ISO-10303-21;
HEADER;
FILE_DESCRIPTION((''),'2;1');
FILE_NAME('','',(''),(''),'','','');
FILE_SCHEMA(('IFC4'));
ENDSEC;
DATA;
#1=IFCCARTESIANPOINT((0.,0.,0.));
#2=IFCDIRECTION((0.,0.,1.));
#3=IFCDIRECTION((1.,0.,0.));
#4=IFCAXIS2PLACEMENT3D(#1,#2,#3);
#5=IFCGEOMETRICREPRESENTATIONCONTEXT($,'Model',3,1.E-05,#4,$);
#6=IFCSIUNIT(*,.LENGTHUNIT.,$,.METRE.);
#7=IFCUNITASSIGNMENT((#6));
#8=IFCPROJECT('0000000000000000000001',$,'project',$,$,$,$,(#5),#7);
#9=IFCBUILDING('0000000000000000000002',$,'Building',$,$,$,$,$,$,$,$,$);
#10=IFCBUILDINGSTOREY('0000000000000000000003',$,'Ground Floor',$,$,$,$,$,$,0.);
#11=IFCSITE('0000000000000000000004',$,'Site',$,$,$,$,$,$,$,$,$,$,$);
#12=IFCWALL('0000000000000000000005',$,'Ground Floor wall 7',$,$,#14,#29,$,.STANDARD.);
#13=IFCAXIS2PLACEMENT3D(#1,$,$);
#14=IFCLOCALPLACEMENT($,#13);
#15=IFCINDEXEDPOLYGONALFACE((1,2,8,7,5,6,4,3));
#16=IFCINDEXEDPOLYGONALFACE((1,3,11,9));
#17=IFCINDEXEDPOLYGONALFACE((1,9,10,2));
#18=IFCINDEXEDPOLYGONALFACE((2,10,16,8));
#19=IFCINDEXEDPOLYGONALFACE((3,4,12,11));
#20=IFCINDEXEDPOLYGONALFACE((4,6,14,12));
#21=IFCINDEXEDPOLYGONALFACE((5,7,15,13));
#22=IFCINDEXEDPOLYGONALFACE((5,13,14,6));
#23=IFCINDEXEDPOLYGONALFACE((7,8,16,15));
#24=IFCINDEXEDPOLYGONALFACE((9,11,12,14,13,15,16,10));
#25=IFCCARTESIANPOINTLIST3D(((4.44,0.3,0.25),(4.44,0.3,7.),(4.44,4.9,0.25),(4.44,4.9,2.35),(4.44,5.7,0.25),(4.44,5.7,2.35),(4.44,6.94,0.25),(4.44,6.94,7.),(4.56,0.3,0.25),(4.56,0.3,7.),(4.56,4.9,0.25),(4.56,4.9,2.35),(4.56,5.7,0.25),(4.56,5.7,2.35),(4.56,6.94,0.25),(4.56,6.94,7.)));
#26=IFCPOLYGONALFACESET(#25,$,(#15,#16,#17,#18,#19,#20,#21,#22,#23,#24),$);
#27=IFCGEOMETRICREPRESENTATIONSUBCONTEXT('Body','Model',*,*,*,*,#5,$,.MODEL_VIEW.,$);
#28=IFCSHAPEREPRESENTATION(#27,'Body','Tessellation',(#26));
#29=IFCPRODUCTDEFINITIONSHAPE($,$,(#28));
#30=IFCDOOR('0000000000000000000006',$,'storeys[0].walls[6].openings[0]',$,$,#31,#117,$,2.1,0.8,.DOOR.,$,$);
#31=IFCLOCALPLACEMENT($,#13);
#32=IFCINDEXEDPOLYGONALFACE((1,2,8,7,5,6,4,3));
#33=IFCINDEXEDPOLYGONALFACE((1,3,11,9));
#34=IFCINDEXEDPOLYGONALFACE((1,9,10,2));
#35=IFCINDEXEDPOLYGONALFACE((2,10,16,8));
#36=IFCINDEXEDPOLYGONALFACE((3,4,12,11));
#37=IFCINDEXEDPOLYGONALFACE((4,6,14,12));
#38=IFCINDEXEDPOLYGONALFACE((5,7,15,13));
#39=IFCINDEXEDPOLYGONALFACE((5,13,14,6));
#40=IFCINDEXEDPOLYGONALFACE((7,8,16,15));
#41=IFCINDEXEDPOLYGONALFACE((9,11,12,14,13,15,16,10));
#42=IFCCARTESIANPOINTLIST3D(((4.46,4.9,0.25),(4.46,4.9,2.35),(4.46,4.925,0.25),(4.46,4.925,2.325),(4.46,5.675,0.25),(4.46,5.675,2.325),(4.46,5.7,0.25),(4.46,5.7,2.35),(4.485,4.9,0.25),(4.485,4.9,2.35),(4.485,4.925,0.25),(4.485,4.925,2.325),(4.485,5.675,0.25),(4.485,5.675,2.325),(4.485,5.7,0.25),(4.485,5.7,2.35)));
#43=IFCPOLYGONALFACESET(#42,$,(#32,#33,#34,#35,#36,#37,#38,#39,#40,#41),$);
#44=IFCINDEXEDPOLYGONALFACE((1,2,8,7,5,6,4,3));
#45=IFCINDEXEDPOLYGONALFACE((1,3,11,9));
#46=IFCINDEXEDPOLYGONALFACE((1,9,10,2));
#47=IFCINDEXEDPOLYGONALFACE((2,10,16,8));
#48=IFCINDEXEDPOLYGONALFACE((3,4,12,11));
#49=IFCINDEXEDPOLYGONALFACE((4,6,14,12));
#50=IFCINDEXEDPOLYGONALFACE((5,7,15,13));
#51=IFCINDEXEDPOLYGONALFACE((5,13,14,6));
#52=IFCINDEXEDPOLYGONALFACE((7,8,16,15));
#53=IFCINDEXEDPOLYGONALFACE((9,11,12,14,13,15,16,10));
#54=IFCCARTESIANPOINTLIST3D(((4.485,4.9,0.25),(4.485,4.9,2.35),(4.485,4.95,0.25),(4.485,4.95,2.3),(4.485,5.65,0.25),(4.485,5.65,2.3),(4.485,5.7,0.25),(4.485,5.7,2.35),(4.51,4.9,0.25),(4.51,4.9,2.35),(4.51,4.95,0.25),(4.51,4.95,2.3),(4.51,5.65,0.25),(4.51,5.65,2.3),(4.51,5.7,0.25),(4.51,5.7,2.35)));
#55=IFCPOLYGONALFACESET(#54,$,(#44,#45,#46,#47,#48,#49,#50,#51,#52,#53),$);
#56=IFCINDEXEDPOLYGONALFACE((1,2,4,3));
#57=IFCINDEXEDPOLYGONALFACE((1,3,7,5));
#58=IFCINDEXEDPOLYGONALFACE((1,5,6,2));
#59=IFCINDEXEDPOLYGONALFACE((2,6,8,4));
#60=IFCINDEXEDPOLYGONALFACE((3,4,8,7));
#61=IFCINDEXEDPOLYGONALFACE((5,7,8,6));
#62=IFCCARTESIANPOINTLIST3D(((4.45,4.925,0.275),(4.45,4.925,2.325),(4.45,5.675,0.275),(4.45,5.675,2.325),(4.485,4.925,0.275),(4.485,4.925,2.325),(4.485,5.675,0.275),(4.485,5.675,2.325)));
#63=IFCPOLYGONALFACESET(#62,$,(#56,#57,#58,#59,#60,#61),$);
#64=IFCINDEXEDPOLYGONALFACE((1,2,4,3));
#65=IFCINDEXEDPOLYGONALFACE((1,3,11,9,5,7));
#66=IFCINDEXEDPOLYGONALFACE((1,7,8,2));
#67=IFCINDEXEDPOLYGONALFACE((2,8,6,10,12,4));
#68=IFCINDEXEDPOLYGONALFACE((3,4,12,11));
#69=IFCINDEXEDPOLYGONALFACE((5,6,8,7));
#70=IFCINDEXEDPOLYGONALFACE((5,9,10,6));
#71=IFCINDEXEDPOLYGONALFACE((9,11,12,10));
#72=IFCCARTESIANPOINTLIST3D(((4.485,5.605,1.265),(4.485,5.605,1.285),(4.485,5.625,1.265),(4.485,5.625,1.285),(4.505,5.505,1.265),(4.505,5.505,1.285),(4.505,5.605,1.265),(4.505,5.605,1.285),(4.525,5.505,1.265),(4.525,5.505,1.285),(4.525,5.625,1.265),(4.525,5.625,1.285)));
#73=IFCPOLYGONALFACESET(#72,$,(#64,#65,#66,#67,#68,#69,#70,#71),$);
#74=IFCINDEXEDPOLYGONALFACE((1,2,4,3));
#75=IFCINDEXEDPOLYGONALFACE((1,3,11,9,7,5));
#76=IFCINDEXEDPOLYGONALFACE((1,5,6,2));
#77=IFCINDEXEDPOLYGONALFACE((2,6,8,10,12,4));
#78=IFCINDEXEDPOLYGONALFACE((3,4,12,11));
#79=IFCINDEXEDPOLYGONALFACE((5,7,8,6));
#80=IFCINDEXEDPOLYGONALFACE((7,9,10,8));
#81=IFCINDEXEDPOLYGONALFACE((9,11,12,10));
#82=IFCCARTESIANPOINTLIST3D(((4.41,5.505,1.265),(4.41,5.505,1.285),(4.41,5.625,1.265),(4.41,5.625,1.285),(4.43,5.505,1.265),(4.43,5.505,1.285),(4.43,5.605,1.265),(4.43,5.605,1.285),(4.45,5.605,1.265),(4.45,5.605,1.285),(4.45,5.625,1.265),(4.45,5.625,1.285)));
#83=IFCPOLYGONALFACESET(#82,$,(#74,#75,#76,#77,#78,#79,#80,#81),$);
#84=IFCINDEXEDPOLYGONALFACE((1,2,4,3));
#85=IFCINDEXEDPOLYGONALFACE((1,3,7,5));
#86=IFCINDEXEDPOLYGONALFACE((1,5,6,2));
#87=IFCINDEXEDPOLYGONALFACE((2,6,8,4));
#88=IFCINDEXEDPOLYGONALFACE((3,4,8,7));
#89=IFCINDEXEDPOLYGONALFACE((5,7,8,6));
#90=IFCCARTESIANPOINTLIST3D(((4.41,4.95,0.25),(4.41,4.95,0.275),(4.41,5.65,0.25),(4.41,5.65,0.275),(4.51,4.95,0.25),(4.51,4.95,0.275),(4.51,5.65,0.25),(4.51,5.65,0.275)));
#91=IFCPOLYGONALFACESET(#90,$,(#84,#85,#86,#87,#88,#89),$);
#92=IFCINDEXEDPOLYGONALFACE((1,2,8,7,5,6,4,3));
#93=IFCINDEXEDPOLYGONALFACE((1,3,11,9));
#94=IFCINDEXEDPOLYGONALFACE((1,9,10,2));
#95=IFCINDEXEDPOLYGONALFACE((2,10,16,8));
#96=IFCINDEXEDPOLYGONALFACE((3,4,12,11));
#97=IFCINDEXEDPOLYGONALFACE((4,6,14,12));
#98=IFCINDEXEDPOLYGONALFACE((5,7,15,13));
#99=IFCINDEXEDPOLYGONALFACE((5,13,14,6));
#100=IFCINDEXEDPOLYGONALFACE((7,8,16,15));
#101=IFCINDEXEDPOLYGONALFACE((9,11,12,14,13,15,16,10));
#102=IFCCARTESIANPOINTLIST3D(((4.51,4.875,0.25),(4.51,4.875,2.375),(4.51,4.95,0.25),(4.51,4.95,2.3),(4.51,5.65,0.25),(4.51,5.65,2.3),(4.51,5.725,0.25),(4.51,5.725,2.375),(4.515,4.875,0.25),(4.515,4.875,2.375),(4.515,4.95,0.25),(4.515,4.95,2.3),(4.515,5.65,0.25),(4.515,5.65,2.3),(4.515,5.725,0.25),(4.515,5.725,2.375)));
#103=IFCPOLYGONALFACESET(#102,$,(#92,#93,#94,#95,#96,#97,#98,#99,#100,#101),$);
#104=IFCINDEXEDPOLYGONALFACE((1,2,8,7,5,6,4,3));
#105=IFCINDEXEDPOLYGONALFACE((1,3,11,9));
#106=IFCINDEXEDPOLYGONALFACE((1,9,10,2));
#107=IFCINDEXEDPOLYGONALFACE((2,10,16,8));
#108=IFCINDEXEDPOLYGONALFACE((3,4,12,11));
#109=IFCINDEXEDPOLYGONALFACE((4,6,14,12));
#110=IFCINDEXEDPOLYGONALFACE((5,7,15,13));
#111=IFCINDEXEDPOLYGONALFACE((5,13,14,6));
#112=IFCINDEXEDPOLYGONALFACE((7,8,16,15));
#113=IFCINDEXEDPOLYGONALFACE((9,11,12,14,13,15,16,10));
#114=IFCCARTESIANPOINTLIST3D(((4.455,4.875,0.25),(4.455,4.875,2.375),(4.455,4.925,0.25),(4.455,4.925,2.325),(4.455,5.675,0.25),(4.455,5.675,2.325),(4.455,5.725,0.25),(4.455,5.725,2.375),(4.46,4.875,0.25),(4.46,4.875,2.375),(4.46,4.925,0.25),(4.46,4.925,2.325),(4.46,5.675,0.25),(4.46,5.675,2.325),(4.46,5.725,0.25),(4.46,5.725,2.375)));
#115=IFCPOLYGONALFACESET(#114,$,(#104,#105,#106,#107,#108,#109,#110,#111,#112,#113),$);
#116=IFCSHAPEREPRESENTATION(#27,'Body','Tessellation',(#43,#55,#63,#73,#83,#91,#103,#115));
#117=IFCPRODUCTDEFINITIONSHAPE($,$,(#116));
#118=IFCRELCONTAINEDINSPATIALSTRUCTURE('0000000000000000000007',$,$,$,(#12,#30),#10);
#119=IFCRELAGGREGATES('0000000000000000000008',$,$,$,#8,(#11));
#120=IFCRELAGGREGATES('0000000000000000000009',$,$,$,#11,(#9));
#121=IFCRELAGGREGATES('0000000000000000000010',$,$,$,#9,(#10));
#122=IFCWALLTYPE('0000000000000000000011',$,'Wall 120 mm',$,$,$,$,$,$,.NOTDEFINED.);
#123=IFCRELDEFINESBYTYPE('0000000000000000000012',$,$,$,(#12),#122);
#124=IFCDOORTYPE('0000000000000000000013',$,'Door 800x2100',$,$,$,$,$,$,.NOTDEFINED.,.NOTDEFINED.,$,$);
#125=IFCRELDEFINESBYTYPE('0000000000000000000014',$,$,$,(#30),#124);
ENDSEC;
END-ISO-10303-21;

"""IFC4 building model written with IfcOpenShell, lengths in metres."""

from ifc_helpers import new_model, si_unit, frame, origin_with_axes, place, context, subcontext, project, spatial, line, indexed_curve, outline, extrude, type_object, element, fill, save


model = new_model("IFC4")

# Units and contexts
model_context = context("Model", 3, precision=1e-05, world=origin_with_axes())
body_context = subcontext(model_context, "Body", "Model", "MODEL_VIEW")
ifc_project = project(units=[si_unit("LENGTHUNIT", "METRE")], contexts=[model_context])

# Site, building, storey
site = spatial("IfcSite", under=ifc_project, Name="Site")
building = spatial("IfcBuilding", under=site, Name="Building")
storey = spatial("IfcBuildingStorey", under=building, Name="Ground Floor", Elevation=0.0)

# Wall, opening, door
wall_type_1 = type_object("IfcWallType", Name="Wall 120 mm", PredefinedType="NOTDEFINED")
wall_1_placement = place(None, frame((4.5, 0.3, 0.25), z_axis=(0.0, 0.0, 1.0), x_axis=(0.0, 1.0, 0.0)))
wall_1 = element("IfcWall", 1, at=wall_1_placement, inside=storey, type_object=wall_type_1, Name="Ground Floor wall 7", PredefinedType="STANDARD", context=body_context, shape_type="SweptSolid", body=[
    extrude(outline(indexed_curve([(0.0, 0.0), (0.0, 0.12), (6.64, 0.12), (6.64, 0.0), (0.0, 0.0)], self_intersect=False)), frame((0.0, -0.06, 0.0), z_axis=(0.0, 0.0, 1.0), x_axis=(1.0, 0.0, 0.0)), (0.0, 0.0, 1.0), 6.75),
])
opening_1_placement = place(wall_1_placement, frame((4.6, -0.07, 0.0), z_axis=(0.0, 0.0, 1.0), x_axis=(1.0, 0.0, 0.0)))
opening_1 = element("IfcOpeningElement", 2, at=opening_1_placement, cuts=wall_1, context=body_context, shape_type="SweptSolid", body=[
    extrude(outline(indexed_curve([(0.0, 0.0), (0.0, 0.14), (0.8, 0.14), (0.8, 0.0), (0.0, 0.0)], self_intersect=False)), origin_with_axes(), (0.0, 0.0, 1.0), 2.1),
])
door_type_1 = type_object("IfcDoorType", Name="Door 800x2100", OperationType="NOTDEFINED", PredefinedType="NOTDEFINED")
door_1_placement = place(None, frame((4.51, 4.9, 0.25), z_axis=(0.0, 0.0, 1.0), x_axis=(0.0, 1.0, 0.0)))
door_1 = element("IfcDoor", 3, at=door_1_placement, inside=storey, type_object=door_type_1, Name="storeys[0].walls[6].openings[0]", OverallHeight=2.1, OverallWidth=0.8, PredefinedType="DOOR", context=body_context, shape_type="SweptSolid", body=[
    extrude(outline(indexed_curve([(0.0, 0.0), (0.0, 2.1), (0.8, 2.1), (0.8, 0.0), (0.775, 0.0), (0.775, 2.075), (0.025, 2.075), (0.025, 0.0)], segments=[line(1, 2, 3, 4, 5, 6, 7, 8, 1)])), frame((0.0, 0.025, 0.0), z_axis=(0.0, -1.0, 0.0), x_axis=(1.0, 0.0, 0.0)), (0.0, 0.0, -1.0), 0.025),
    extrude(outline(indexed_curve([(0.0, 0.0), (0.0, 2.1), (0.8, 2.1), (0.8, 0.0), (0.75, 0.0), (0.75, 2.05), (0.05, 2.05), (0.05, 0.0)], segments=[line(1, 2, 3, 4, 5, 6, 7, 8, 1)])), frame((0.0, 0.0, 0.0), z_axis=(0.0, -1.0, 0.0), x_axis=(1.0, 0.0, 0.0)), (0.0, 0.0, -1.0), 0.025),
    extrude(outline(indexed_curve([(0.0, 0.0), (0.75, 0.0), (0.75, 0.035), (0.0, 0.035)], segments=[line(1, 2, 3, 4, 1)])), frame((0.025, 0.025, 0.025), z_axis=(0.0, 0.0, 1.0), x_axis=(1.0, 0.0, 0.0)), (0.0, 0.0, 1.0), 2.05),
    extrude(outline(indexed_curve([(0.0, 0.0), (0.0, -0.04), (-0.12, -0.04), (-0.12, -0.02), (-0.02, -0.02), (-0.02, 0.0)], segments=[line(1, 2, 3, 4, 5, 6, 1)])), frame((0.725, 0.025, 1.015), z_axis=(0.0, 0.0, 1.0), x_axis=(1.0, 0.0, 0.0)), (0.0, 0.0, 1.0), 0.02),
    extrude(outline(indexed_curve([(0.0, 0.0), (0.0, 0.04), (-0.12, 0.04), (-0.12, 0.02), (-0.02, 0.02), (-0.02, 0.0)], segments=[line(1, 2, 3, 4, 5, 6, 1)])), frame((0.725, 0.06, 1.015), z_axis=(0.0, 0.0, 1.0), x_axis=(1.0, 0.0, 0.0)), (0.0, 0.0, 1.0), 0.02),
    extrude(outline(indexed_curve([(0.0, 0.0), (0.7, 0.0), (0.7, 0.1), (0.0, 0.1)], segments=[line(1, 2, 3, 4, 1)])), frame((0.05, 0.0, 0.0), z_axis=(0.0, 0.0, 1.0), x_axis=(1.0, 0.0, 0.0)), (0.0, 0.0, 1.0), 0.025),
    extrude(outline(indexed_curve([(0.0, 0.0), (0.0, 2.125), (0.85, 2.125), (0.85, 0.0), (0.775, 0.0), (0.775, 2.05), (0.075, 2.05), (0.075, 0.0)], segments=[line(1, 2, 3, 4, 5, 6, 7, 8, 1)])), frame((-0.025, -0.005, 0.0), z_axis=(0.0, -1.0, 0.0), x_axis=(1.0, 0.0, 0.0)), (0.0, 0.0, -1.0), 0.005),
    extrude(outline(indexed_curve([(0.0, 0.0), (0.0, 2.125), (0.85, 2.125), (0.85, 0.0), (0.8, 0.0), (0.8, 2.075), (0.05, 2.075), (0.05, 0.0)], segments=[line(1, 2, 3, 4, 5, 6, 7, 8, 1)])), frame((-0.025, 0.05, 0.0), z_axis=(0.0, -1.0, 0.0), x_axis=(1.0, 0.0, 0.0)), (0.0, 0.0, -1.0), 0.005),
])
fill(opening_1, door_1)

save(model, "model.ifc")
